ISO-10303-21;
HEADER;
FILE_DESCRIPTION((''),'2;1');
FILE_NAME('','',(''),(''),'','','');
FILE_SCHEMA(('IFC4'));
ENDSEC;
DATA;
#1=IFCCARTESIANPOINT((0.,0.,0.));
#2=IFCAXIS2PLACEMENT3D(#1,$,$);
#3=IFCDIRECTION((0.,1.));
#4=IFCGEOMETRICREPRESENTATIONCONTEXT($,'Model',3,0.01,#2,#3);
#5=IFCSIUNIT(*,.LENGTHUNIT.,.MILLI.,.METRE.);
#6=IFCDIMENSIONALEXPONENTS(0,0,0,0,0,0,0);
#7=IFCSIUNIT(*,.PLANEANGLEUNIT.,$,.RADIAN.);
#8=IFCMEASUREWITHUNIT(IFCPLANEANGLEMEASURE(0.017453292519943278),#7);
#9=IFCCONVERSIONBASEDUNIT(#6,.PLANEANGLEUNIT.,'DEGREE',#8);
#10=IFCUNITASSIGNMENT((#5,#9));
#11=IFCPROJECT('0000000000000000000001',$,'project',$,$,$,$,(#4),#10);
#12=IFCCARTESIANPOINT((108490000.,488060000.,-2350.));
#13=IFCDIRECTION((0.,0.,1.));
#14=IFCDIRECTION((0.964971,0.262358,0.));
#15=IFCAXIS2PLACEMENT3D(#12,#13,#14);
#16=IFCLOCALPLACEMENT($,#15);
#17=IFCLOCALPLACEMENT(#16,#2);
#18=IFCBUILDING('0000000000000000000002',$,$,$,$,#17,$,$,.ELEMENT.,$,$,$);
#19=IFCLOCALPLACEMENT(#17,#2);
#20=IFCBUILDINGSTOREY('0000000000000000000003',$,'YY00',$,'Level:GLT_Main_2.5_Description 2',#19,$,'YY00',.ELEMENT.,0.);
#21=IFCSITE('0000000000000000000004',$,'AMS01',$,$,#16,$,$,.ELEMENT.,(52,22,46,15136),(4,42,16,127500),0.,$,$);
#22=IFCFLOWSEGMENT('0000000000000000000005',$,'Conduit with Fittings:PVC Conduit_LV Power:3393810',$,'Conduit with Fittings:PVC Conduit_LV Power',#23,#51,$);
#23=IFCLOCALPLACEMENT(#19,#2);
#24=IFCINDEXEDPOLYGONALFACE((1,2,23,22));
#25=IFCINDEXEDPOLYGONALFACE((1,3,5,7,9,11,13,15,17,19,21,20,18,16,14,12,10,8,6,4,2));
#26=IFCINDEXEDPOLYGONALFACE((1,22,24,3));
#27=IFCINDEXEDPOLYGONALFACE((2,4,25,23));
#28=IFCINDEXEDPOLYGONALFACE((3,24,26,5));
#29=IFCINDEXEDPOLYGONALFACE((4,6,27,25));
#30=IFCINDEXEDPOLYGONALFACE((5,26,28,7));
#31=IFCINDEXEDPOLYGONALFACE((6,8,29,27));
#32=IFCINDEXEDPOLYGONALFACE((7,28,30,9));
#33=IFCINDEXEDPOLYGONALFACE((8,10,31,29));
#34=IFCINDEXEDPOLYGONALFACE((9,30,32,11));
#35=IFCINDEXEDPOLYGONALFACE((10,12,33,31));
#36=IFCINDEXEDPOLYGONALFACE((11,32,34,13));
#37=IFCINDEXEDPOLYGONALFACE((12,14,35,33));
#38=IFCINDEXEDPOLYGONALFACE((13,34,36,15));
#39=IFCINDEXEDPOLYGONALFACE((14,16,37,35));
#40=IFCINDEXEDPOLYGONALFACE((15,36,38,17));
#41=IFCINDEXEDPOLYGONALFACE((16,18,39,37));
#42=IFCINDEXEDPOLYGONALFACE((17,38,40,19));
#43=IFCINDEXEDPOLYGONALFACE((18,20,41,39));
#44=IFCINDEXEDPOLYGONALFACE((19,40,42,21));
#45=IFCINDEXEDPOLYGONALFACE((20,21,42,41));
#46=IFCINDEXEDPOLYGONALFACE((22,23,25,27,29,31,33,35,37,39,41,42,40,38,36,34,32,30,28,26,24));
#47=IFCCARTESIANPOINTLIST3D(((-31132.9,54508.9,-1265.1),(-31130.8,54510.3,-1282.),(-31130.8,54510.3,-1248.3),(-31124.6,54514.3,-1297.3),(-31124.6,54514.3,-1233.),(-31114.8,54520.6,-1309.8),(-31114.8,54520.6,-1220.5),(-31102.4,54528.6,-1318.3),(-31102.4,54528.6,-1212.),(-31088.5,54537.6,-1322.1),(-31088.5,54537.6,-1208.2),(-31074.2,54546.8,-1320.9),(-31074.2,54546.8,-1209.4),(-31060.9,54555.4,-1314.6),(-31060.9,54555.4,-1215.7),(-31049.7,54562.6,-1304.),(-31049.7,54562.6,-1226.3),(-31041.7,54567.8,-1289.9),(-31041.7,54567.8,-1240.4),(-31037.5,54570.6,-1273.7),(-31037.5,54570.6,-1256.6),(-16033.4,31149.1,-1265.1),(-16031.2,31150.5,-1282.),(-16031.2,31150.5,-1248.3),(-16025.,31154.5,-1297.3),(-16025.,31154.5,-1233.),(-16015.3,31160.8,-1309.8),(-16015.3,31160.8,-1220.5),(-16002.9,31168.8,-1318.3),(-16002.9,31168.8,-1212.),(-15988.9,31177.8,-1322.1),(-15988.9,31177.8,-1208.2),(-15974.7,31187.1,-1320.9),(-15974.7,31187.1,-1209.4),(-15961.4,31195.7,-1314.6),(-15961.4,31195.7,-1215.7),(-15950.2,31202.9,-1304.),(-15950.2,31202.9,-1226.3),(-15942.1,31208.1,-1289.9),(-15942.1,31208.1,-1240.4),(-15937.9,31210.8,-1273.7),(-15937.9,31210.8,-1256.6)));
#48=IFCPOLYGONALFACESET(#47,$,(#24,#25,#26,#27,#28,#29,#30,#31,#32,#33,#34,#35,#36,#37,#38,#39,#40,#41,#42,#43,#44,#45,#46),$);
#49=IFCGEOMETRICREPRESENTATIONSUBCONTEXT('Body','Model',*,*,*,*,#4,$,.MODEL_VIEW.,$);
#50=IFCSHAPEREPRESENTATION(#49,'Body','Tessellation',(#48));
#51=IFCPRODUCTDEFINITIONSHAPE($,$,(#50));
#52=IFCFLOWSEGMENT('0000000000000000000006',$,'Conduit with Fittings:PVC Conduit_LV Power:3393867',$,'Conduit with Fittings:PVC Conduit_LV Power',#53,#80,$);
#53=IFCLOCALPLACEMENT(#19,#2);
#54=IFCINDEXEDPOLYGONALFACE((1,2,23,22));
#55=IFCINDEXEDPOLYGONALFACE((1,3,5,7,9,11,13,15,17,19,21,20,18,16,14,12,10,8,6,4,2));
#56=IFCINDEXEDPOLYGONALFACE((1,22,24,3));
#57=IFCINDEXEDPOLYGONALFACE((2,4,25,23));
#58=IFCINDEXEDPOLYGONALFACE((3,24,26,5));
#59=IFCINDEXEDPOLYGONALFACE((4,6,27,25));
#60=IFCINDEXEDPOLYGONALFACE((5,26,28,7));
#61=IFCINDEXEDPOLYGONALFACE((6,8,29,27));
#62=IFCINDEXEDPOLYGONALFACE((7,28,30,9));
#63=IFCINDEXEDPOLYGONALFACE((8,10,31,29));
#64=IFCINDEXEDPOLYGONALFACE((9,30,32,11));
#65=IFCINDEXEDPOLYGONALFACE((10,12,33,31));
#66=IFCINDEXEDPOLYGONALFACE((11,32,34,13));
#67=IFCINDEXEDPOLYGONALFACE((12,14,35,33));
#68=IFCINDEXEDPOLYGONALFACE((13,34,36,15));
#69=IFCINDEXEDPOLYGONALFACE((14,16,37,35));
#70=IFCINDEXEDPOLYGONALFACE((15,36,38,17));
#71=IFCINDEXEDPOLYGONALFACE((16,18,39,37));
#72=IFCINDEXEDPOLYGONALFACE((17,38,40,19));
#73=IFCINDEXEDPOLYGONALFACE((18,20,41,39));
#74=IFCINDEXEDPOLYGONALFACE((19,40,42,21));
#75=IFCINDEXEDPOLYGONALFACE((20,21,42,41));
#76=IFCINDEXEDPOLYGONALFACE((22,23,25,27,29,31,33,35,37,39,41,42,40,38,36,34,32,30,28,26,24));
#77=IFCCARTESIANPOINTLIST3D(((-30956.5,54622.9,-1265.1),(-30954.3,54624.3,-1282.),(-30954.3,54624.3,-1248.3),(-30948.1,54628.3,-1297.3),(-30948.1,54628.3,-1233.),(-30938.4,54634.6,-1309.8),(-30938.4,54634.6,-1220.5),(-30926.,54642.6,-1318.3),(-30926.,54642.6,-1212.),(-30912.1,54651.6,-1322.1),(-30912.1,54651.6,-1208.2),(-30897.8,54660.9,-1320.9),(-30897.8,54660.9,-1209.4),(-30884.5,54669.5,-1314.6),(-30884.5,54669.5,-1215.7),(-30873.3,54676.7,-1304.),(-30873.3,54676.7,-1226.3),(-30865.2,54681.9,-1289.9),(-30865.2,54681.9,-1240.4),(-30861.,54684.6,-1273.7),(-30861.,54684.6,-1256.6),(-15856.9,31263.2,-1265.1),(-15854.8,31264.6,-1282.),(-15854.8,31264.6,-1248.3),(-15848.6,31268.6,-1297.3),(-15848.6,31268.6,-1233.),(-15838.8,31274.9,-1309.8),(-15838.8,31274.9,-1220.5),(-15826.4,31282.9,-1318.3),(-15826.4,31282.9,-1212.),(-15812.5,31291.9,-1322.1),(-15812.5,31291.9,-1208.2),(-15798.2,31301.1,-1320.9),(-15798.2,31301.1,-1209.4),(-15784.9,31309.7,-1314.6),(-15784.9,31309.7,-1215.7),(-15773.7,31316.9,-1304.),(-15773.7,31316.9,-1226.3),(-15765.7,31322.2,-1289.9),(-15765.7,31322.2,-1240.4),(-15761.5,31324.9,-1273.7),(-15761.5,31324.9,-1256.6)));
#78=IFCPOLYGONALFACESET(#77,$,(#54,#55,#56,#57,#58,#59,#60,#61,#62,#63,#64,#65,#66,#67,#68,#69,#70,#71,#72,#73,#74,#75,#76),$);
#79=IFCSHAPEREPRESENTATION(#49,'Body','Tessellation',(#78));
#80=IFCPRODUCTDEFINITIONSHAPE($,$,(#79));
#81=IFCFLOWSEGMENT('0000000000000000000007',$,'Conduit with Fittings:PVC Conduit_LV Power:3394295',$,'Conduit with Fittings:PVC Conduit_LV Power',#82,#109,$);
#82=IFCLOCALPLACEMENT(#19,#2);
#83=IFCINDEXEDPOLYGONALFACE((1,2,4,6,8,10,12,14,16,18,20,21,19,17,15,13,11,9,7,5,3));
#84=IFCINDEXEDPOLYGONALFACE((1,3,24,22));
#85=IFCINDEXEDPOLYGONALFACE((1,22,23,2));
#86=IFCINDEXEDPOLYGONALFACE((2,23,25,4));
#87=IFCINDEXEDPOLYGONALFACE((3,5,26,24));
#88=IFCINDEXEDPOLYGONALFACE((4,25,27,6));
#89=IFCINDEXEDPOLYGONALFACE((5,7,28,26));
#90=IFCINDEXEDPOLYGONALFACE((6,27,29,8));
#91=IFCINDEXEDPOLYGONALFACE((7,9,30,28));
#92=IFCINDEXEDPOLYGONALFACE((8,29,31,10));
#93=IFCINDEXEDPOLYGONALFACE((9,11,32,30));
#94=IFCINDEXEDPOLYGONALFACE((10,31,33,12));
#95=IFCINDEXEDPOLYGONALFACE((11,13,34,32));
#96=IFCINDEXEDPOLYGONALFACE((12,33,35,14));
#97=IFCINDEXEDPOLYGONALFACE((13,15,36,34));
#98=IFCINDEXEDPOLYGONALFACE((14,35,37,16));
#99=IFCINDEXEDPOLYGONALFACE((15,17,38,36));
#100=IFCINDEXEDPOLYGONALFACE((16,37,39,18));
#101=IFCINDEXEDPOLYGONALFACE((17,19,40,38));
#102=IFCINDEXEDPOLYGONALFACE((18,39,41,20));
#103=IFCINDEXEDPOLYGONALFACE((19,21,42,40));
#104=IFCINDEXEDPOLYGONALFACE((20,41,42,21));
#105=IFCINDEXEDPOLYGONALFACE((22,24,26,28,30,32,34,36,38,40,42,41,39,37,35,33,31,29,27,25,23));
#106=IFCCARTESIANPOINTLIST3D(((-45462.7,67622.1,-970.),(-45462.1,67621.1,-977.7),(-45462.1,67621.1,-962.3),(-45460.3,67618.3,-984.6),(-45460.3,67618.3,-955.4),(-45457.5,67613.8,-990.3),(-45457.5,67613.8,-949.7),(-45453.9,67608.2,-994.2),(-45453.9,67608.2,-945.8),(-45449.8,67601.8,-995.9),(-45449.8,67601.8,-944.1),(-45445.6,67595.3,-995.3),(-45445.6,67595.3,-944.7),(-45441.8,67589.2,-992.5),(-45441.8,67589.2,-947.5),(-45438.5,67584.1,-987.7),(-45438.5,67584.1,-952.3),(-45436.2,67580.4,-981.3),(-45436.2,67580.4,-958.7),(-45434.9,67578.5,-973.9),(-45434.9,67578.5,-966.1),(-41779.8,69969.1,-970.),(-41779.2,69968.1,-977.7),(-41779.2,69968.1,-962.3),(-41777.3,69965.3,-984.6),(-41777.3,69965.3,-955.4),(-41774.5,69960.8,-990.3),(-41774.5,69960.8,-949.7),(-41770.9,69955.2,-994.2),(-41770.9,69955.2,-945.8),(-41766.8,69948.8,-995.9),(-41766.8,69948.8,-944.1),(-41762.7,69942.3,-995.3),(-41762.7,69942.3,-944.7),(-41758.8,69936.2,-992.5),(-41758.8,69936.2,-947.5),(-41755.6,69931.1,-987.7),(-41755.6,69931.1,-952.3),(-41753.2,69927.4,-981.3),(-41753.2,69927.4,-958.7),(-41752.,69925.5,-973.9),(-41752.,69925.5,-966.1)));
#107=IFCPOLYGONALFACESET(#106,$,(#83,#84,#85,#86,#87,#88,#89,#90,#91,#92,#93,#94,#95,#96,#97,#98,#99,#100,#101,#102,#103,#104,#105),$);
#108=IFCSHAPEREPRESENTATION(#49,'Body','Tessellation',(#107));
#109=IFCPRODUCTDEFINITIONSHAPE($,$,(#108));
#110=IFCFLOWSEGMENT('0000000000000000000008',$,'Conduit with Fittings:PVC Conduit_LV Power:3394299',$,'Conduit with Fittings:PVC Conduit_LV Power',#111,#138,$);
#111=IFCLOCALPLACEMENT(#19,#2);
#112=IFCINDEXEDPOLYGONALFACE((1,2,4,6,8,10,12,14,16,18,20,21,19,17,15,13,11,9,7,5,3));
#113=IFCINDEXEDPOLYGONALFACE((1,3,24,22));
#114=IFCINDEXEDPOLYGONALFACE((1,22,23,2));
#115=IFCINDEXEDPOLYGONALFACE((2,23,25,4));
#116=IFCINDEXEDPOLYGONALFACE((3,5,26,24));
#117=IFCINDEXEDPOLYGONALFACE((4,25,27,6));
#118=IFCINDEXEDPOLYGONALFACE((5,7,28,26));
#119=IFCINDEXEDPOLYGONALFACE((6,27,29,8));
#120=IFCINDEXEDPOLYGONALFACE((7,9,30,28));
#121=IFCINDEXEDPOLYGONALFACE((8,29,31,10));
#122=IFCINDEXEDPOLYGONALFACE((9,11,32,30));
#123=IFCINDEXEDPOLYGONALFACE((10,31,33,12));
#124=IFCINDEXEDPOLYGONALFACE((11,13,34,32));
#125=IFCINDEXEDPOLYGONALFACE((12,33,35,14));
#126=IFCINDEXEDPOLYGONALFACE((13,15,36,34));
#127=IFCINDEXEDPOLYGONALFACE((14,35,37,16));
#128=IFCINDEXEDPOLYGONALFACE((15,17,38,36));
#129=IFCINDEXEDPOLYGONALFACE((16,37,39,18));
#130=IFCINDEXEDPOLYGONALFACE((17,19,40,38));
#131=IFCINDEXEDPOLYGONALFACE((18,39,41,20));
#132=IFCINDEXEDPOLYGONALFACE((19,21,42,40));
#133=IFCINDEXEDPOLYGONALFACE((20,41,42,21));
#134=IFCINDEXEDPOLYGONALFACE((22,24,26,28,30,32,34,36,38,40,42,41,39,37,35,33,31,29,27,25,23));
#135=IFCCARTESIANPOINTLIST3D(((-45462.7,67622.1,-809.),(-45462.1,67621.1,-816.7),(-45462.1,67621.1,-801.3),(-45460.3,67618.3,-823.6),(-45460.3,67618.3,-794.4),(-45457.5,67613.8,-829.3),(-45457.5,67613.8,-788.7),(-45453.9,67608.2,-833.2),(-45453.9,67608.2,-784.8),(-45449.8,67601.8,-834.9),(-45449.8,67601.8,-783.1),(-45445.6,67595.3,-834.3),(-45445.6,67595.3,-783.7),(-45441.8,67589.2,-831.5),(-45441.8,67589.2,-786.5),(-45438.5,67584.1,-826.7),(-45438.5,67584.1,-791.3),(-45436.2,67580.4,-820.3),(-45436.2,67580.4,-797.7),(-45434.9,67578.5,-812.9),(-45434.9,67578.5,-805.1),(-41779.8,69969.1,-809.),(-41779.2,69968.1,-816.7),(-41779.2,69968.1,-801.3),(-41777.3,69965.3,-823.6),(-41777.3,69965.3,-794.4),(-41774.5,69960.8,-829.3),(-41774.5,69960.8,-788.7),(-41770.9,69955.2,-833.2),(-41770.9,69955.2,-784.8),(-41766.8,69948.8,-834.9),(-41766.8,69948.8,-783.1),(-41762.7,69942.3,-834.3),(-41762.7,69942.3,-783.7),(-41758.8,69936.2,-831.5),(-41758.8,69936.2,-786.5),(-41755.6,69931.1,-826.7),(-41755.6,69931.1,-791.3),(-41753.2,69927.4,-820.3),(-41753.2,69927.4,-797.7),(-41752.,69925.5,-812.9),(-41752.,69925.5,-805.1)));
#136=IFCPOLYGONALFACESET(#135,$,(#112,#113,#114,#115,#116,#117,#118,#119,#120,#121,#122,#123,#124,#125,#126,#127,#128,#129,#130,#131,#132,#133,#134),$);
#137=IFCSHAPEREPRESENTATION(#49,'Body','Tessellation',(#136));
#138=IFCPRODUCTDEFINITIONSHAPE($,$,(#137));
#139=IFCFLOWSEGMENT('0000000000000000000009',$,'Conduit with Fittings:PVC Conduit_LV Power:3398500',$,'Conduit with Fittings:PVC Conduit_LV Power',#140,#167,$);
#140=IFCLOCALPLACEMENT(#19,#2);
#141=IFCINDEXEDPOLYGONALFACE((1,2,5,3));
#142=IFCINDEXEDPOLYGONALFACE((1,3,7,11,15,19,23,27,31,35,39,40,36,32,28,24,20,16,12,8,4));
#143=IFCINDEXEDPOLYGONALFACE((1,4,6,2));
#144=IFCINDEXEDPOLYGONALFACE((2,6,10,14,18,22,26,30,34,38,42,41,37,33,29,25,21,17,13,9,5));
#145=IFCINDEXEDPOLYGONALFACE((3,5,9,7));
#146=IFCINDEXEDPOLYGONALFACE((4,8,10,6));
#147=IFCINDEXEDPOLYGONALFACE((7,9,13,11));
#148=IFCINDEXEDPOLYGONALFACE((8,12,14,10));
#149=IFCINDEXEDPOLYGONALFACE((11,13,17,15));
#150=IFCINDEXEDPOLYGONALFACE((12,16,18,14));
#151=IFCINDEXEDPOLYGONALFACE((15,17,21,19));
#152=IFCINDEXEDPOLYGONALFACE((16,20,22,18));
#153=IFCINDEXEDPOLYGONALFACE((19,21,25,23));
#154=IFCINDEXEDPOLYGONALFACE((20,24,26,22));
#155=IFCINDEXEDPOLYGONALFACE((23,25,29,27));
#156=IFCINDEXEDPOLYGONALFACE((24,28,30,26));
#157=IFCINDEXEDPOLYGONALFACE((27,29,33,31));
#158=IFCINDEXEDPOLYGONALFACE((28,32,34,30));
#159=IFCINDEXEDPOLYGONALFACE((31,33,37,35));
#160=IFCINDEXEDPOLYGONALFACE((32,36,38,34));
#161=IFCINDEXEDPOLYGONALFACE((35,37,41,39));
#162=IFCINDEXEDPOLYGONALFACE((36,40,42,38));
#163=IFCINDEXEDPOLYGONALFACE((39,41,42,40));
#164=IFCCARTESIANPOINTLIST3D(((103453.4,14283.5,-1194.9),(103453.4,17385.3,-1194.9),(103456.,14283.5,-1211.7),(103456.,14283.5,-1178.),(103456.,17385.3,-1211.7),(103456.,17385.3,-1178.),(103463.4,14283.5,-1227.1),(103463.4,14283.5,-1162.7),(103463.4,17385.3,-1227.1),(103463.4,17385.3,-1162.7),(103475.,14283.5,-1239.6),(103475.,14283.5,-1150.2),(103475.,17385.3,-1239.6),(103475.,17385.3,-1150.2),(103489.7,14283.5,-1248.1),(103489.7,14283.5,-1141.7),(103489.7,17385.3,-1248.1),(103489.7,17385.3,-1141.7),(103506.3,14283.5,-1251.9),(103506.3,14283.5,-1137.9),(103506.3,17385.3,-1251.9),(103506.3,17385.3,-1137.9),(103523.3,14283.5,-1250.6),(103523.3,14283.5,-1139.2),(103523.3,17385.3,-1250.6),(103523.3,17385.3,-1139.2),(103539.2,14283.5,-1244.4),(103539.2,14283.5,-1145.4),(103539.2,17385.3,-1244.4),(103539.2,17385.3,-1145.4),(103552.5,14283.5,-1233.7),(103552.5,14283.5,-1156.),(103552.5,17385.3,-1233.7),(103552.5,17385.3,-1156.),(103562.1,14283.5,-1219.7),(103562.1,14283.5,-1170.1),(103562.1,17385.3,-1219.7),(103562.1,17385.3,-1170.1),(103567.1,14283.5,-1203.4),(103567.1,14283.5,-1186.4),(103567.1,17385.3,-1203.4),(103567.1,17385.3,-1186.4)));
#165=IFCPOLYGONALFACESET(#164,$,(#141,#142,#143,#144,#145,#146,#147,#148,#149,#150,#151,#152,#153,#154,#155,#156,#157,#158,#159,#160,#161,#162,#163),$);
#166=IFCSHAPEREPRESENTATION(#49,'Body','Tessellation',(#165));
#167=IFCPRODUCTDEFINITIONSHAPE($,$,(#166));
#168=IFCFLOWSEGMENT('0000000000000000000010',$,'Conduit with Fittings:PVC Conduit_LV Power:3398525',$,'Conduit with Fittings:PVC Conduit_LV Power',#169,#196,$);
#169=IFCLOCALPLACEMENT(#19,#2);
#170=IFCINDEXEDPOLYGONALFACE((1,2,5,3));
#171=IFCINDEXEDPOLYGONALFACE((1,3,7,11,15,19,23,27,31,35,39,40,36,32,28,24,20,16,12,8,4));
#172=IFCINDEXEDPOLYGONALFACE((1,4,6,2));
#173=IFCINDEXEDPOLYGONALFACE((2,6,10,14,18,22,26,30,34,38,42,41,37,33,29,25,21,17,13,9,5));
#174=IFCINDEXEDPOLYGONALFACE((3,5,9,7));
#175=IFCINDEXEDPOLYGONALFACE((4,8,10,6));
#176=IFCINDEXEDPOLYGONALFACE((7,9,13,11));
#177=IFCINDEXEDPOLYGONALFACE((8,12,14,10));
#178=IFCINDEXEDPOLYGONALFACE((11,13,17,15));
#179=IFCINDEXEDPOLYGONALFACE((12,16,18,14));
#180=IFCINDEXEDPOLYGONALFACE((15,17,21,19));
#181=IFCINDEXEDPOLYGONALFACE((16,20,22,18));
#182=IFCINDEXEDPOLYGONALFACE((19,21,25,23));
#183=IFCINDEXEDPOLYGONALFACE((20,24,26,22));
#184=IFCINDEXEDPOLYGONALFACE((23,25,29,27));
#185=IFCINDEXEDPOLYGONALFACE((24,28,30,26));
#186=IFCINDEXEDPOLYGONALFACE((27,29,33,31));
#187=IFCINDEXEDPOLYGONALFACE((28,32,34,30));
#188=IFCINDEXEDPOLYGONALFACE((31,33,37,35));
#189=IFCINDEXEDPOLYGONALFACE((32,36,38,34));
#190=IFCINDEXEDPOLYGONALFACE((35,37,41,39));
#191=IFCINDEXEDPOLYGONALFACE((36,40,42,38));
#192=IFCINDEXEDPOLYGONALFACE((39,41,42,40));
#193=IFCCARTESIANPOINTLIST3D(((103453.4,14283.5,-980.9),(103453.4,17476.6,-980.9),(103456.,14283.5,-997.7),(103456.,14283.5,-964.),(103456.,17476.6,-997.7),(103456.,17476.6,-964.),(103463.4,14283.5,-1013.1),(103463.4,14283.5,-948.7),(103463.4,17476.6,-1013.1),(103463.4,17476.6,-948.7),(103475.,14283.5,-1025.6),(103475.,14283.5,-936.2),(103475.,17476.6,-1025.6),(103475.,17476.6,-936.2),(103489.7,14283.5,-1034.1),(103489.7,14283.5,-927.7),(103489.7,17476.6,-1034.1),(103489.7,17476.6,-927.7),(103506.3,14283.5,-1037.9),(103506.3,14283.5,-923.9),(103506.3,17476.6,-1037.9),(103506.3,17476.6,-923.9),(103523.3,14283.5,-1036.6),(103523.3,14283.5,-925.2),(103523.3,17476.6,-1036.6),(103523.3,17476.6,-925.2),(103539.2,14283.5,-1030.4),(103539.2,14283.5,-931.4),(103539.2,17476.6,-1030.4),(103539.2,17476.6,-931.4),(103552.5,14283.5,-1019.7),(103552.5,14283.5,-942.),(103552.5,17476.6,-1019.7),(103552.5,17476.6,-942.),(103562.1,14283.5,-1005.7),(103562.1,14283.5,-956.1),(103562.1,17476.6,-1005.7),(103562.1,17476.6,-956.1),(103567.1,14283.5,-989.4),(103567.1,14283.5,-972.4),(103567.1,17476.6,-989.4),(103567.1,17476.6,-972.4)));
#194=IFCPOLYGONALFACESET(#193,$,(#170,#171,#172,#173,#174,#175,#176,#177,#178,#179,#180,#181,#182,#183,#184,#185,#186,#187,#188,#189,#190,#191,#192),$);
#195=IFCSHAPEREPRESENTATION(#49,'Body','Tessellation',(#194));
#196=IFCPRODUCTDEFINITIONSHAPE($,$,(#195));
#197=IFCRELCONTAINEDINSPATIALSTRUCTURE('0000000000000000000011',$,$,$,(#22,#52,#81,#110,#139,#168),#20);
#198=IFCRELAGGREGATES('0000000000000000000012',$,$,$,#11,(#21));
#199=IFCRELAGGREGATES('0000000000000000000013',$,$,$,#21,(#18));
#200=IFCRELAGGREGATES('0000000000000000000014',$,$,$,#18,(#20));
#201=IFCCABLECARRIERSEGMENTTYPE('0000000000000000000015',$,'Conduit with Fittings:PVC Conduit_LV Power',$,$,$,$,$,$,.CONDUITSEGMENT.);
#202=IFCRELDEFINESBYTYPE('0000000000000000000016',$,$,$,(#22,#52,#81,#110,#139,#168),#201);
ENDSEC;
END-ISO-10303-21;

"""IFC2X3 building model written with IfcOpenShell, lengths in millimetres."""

from ifc_helpers import new_model, entity, si_unit, converted_unit, direction, frame, frame_2d, origin, origin_2d_with_axis, place, context, subcontext, project, spatial, circle, extrude, type_object, element, save


model = new_model("IFC2X3")

# Units and contexts
model_context = context("Model", 3, precision=0.01, world=origin(), true_north=direction((0.0, 1.0)))
body_context = subcontext(model_context, "Body", "Model", "MODEL_VIEW")
ifc_project = project(units=[si_unit("LENGTHUNIT", "METRE", prefix="MILLI"), converted_unit("PLANEANGLEUNIT", "DEGREE", entity("IfcPlaneAngleMeasure", 0.017453292519943278), si_unit("PLANEANGLEUNIT", "RADIAN"), dimensions=[0, 0, 0, 0, 0, 0, 0])], contexts=[model_context])

# Site, building, storey
site_placement = place(None, frame((108490000.0, 488060000.0, -2350.0), z_axis=(0.0, 0.0, 1.0), x_axis=(0.964971, 0.262358, 0.0)))
site = spatial("IfcSite", under=ifc_project, at=site_placement, Name="AMS01", CompositionType="ELEMENT", RefLatitude=(52, 22, 46, 15136), RefLongitude=(4, 42, 16, 127500), RefElevation=0.0)
building_placement = place(site_placement, origin())
building = spatial("IfcBuilding", under=site, at=building_placement, CompositionType="ELEMENT")
storey_placement = place(building_placement, origin())
storey = spatial("IfcBuildingStorey", under=building, at=storey_placement, Name="YY00", ObjectType="Level:GLT_Main_2.5_Description 2", LongName="YY00", CompositionType="ELEMENT", Elevation=0.0)

# Flow segments
cable_carrier_segment_type = type_object("IfcCableCarrierSegmentType", Name="Conduit with Fittings:PVC Conduit_LV Power", PredefinedType="CONDUITSEGMENT")
flow_segment_1_placement = place(storey_placement, origin())
element("IfcFlowSegment", 1, at=flow_segment_1_placement, inside=storey, type_object=cable_carrier_segment_type, Name="Conduit with Fittings:PVC Conduit_LV Power:3393810", ObjectType="Conduit with Fittings:PVC Conduit_LV Power", context=body_context, shape_type="SweptSolid", body=[
    extrude(circle(Radius=57.2, at=frame_2d((0.0, 0.0), x_axis=(1.0, 0.0))), frame((-15985.4, 31180.2, -1265.1), z_axis=(-0.542856, 0.839826, 0.0), x_axis=(-0.839826, -0.542856, 0.0)), (0.0, 0.0, 1.0), 27815.0),
])
flow_segment_2_placement = place(storey_placement, origin())
element("IfcFlowSegment", 2, at=flow_segment_2_placement, inside=storey, type_object=cable_carrier_segment_type, Name="Conduit with Fittings:PVC Conduit_LV Power:3393867", ObjectType="Conduit with Fittings:PVC Conduit_LV Power", context=body_context, shape_type="SweptSolid", body=[
    extrude(circle(Radius=57.2, at=origin_2d_with_axis()), frame((-30908.5, 54654.0, -1265.1), z_axis=(0.542856, -0.839826, 0.0), x_axis=(-0.839826, -0.542856, 0.0)), (0.0, 0.0, 1.0), 27815.0),
])
flow_segment_3_placement = place(storey_placement, origin())
element("IfcFlowSegment", 3, at=flow_segment_3_placement, inside=storey, type_object=cable_carrier_segment_type, Name="Conduit with Fittings:PVC Conduit_LV Power:3394295", ObjectType="Conduit with Fittings:PVC Conduit_LV Power", context=body_context, shape_type="SweptSolid", body=[
    extrude(circle(Radius=26.0, at=origin_2d_with_axis()), frame((-45448.7, 67600.2, -970.0), z_axis=(0.843321, 0.53741, 0.0), x_axis=(-0.53741, 0.843321, 0.0)), (0.0, 0.0, 1.0), 4367.2),
])
flow_segment_4_placement = place(storey_placement, origin())
element("IfcFlowSegment", 4, at=flow_segment_4_placement, inside=storey, type_object=cable_carrier_segment_type, Name="Conduit with Fittings:PVC Conduit_LV Power:3394299", ObjectType="Conduit with Fittings:PVC Conduit_LV Power", context=body_context, shape_type="SweptSolid", body=[
    extrude(circle(Radius=26.0, at=frame_2d((0.0, 0.0), x_axis=(1.0, 0.0))), frame((-45448.7, 67600.2, -809.0), z_axis=(0.843321, 0.53741, 0.0), x_axis=(-0.53741, 0.843321, 0.0)), (0.0, 0.0, 1.0), 4367.2),
])
flow_segment_5_placement = place(storey_placement, origin())
element("IfcFlowSegment", 5, at=flow_segment_5_placement, inside=storey, type_object=cable_carrier_segment_type, Name="Conduit with Fittings:PVC Conduit_LV Power:3398500", ObjectType="Conduit with Fittings:PVC Conduit_LV Power", context=body_context, shape_type="SweptSolid", body=[
    extrude(circle(Radius=57.2, at=frame_2d((0.0, 0.0), x_axis=(1.0, 0.0))), frame((103510.6, 14283.5, -1194.9), z_axis=(0.0, 1.0, 0.0), x_axis=(-1.0, 0.0, 0.0)), (0.0, 0.0, 1.0), 3101.8),
])
flow_segment_6_placement = place(storey_placement, origin())
element("IfcFlowSegment", 6, at=flow_segment_6_placement, inside=storey, type_object=cable_carrier_segment_type, Name="Conduit with Fittings:PVC Conduit_LV Power:3398525", ObjectType="Conduit with Fittings:PVC Conduit_LV Power", context=body_context, shape_type="SweptSolid", body=[
    extrude(circle(Radius=57.2, at=frame_2d((0.0, 0.0), x_axis=(1.0, 0.0))), frame((103510.6, 14283.5, -980.9), z_axis=(0.0, 1.0, 0.0), x_axis=(-1.0, 0.0, 0.0)), (0.0, 0.0, 1.0), 3193.1),
])

save(model, "model.ifc")
